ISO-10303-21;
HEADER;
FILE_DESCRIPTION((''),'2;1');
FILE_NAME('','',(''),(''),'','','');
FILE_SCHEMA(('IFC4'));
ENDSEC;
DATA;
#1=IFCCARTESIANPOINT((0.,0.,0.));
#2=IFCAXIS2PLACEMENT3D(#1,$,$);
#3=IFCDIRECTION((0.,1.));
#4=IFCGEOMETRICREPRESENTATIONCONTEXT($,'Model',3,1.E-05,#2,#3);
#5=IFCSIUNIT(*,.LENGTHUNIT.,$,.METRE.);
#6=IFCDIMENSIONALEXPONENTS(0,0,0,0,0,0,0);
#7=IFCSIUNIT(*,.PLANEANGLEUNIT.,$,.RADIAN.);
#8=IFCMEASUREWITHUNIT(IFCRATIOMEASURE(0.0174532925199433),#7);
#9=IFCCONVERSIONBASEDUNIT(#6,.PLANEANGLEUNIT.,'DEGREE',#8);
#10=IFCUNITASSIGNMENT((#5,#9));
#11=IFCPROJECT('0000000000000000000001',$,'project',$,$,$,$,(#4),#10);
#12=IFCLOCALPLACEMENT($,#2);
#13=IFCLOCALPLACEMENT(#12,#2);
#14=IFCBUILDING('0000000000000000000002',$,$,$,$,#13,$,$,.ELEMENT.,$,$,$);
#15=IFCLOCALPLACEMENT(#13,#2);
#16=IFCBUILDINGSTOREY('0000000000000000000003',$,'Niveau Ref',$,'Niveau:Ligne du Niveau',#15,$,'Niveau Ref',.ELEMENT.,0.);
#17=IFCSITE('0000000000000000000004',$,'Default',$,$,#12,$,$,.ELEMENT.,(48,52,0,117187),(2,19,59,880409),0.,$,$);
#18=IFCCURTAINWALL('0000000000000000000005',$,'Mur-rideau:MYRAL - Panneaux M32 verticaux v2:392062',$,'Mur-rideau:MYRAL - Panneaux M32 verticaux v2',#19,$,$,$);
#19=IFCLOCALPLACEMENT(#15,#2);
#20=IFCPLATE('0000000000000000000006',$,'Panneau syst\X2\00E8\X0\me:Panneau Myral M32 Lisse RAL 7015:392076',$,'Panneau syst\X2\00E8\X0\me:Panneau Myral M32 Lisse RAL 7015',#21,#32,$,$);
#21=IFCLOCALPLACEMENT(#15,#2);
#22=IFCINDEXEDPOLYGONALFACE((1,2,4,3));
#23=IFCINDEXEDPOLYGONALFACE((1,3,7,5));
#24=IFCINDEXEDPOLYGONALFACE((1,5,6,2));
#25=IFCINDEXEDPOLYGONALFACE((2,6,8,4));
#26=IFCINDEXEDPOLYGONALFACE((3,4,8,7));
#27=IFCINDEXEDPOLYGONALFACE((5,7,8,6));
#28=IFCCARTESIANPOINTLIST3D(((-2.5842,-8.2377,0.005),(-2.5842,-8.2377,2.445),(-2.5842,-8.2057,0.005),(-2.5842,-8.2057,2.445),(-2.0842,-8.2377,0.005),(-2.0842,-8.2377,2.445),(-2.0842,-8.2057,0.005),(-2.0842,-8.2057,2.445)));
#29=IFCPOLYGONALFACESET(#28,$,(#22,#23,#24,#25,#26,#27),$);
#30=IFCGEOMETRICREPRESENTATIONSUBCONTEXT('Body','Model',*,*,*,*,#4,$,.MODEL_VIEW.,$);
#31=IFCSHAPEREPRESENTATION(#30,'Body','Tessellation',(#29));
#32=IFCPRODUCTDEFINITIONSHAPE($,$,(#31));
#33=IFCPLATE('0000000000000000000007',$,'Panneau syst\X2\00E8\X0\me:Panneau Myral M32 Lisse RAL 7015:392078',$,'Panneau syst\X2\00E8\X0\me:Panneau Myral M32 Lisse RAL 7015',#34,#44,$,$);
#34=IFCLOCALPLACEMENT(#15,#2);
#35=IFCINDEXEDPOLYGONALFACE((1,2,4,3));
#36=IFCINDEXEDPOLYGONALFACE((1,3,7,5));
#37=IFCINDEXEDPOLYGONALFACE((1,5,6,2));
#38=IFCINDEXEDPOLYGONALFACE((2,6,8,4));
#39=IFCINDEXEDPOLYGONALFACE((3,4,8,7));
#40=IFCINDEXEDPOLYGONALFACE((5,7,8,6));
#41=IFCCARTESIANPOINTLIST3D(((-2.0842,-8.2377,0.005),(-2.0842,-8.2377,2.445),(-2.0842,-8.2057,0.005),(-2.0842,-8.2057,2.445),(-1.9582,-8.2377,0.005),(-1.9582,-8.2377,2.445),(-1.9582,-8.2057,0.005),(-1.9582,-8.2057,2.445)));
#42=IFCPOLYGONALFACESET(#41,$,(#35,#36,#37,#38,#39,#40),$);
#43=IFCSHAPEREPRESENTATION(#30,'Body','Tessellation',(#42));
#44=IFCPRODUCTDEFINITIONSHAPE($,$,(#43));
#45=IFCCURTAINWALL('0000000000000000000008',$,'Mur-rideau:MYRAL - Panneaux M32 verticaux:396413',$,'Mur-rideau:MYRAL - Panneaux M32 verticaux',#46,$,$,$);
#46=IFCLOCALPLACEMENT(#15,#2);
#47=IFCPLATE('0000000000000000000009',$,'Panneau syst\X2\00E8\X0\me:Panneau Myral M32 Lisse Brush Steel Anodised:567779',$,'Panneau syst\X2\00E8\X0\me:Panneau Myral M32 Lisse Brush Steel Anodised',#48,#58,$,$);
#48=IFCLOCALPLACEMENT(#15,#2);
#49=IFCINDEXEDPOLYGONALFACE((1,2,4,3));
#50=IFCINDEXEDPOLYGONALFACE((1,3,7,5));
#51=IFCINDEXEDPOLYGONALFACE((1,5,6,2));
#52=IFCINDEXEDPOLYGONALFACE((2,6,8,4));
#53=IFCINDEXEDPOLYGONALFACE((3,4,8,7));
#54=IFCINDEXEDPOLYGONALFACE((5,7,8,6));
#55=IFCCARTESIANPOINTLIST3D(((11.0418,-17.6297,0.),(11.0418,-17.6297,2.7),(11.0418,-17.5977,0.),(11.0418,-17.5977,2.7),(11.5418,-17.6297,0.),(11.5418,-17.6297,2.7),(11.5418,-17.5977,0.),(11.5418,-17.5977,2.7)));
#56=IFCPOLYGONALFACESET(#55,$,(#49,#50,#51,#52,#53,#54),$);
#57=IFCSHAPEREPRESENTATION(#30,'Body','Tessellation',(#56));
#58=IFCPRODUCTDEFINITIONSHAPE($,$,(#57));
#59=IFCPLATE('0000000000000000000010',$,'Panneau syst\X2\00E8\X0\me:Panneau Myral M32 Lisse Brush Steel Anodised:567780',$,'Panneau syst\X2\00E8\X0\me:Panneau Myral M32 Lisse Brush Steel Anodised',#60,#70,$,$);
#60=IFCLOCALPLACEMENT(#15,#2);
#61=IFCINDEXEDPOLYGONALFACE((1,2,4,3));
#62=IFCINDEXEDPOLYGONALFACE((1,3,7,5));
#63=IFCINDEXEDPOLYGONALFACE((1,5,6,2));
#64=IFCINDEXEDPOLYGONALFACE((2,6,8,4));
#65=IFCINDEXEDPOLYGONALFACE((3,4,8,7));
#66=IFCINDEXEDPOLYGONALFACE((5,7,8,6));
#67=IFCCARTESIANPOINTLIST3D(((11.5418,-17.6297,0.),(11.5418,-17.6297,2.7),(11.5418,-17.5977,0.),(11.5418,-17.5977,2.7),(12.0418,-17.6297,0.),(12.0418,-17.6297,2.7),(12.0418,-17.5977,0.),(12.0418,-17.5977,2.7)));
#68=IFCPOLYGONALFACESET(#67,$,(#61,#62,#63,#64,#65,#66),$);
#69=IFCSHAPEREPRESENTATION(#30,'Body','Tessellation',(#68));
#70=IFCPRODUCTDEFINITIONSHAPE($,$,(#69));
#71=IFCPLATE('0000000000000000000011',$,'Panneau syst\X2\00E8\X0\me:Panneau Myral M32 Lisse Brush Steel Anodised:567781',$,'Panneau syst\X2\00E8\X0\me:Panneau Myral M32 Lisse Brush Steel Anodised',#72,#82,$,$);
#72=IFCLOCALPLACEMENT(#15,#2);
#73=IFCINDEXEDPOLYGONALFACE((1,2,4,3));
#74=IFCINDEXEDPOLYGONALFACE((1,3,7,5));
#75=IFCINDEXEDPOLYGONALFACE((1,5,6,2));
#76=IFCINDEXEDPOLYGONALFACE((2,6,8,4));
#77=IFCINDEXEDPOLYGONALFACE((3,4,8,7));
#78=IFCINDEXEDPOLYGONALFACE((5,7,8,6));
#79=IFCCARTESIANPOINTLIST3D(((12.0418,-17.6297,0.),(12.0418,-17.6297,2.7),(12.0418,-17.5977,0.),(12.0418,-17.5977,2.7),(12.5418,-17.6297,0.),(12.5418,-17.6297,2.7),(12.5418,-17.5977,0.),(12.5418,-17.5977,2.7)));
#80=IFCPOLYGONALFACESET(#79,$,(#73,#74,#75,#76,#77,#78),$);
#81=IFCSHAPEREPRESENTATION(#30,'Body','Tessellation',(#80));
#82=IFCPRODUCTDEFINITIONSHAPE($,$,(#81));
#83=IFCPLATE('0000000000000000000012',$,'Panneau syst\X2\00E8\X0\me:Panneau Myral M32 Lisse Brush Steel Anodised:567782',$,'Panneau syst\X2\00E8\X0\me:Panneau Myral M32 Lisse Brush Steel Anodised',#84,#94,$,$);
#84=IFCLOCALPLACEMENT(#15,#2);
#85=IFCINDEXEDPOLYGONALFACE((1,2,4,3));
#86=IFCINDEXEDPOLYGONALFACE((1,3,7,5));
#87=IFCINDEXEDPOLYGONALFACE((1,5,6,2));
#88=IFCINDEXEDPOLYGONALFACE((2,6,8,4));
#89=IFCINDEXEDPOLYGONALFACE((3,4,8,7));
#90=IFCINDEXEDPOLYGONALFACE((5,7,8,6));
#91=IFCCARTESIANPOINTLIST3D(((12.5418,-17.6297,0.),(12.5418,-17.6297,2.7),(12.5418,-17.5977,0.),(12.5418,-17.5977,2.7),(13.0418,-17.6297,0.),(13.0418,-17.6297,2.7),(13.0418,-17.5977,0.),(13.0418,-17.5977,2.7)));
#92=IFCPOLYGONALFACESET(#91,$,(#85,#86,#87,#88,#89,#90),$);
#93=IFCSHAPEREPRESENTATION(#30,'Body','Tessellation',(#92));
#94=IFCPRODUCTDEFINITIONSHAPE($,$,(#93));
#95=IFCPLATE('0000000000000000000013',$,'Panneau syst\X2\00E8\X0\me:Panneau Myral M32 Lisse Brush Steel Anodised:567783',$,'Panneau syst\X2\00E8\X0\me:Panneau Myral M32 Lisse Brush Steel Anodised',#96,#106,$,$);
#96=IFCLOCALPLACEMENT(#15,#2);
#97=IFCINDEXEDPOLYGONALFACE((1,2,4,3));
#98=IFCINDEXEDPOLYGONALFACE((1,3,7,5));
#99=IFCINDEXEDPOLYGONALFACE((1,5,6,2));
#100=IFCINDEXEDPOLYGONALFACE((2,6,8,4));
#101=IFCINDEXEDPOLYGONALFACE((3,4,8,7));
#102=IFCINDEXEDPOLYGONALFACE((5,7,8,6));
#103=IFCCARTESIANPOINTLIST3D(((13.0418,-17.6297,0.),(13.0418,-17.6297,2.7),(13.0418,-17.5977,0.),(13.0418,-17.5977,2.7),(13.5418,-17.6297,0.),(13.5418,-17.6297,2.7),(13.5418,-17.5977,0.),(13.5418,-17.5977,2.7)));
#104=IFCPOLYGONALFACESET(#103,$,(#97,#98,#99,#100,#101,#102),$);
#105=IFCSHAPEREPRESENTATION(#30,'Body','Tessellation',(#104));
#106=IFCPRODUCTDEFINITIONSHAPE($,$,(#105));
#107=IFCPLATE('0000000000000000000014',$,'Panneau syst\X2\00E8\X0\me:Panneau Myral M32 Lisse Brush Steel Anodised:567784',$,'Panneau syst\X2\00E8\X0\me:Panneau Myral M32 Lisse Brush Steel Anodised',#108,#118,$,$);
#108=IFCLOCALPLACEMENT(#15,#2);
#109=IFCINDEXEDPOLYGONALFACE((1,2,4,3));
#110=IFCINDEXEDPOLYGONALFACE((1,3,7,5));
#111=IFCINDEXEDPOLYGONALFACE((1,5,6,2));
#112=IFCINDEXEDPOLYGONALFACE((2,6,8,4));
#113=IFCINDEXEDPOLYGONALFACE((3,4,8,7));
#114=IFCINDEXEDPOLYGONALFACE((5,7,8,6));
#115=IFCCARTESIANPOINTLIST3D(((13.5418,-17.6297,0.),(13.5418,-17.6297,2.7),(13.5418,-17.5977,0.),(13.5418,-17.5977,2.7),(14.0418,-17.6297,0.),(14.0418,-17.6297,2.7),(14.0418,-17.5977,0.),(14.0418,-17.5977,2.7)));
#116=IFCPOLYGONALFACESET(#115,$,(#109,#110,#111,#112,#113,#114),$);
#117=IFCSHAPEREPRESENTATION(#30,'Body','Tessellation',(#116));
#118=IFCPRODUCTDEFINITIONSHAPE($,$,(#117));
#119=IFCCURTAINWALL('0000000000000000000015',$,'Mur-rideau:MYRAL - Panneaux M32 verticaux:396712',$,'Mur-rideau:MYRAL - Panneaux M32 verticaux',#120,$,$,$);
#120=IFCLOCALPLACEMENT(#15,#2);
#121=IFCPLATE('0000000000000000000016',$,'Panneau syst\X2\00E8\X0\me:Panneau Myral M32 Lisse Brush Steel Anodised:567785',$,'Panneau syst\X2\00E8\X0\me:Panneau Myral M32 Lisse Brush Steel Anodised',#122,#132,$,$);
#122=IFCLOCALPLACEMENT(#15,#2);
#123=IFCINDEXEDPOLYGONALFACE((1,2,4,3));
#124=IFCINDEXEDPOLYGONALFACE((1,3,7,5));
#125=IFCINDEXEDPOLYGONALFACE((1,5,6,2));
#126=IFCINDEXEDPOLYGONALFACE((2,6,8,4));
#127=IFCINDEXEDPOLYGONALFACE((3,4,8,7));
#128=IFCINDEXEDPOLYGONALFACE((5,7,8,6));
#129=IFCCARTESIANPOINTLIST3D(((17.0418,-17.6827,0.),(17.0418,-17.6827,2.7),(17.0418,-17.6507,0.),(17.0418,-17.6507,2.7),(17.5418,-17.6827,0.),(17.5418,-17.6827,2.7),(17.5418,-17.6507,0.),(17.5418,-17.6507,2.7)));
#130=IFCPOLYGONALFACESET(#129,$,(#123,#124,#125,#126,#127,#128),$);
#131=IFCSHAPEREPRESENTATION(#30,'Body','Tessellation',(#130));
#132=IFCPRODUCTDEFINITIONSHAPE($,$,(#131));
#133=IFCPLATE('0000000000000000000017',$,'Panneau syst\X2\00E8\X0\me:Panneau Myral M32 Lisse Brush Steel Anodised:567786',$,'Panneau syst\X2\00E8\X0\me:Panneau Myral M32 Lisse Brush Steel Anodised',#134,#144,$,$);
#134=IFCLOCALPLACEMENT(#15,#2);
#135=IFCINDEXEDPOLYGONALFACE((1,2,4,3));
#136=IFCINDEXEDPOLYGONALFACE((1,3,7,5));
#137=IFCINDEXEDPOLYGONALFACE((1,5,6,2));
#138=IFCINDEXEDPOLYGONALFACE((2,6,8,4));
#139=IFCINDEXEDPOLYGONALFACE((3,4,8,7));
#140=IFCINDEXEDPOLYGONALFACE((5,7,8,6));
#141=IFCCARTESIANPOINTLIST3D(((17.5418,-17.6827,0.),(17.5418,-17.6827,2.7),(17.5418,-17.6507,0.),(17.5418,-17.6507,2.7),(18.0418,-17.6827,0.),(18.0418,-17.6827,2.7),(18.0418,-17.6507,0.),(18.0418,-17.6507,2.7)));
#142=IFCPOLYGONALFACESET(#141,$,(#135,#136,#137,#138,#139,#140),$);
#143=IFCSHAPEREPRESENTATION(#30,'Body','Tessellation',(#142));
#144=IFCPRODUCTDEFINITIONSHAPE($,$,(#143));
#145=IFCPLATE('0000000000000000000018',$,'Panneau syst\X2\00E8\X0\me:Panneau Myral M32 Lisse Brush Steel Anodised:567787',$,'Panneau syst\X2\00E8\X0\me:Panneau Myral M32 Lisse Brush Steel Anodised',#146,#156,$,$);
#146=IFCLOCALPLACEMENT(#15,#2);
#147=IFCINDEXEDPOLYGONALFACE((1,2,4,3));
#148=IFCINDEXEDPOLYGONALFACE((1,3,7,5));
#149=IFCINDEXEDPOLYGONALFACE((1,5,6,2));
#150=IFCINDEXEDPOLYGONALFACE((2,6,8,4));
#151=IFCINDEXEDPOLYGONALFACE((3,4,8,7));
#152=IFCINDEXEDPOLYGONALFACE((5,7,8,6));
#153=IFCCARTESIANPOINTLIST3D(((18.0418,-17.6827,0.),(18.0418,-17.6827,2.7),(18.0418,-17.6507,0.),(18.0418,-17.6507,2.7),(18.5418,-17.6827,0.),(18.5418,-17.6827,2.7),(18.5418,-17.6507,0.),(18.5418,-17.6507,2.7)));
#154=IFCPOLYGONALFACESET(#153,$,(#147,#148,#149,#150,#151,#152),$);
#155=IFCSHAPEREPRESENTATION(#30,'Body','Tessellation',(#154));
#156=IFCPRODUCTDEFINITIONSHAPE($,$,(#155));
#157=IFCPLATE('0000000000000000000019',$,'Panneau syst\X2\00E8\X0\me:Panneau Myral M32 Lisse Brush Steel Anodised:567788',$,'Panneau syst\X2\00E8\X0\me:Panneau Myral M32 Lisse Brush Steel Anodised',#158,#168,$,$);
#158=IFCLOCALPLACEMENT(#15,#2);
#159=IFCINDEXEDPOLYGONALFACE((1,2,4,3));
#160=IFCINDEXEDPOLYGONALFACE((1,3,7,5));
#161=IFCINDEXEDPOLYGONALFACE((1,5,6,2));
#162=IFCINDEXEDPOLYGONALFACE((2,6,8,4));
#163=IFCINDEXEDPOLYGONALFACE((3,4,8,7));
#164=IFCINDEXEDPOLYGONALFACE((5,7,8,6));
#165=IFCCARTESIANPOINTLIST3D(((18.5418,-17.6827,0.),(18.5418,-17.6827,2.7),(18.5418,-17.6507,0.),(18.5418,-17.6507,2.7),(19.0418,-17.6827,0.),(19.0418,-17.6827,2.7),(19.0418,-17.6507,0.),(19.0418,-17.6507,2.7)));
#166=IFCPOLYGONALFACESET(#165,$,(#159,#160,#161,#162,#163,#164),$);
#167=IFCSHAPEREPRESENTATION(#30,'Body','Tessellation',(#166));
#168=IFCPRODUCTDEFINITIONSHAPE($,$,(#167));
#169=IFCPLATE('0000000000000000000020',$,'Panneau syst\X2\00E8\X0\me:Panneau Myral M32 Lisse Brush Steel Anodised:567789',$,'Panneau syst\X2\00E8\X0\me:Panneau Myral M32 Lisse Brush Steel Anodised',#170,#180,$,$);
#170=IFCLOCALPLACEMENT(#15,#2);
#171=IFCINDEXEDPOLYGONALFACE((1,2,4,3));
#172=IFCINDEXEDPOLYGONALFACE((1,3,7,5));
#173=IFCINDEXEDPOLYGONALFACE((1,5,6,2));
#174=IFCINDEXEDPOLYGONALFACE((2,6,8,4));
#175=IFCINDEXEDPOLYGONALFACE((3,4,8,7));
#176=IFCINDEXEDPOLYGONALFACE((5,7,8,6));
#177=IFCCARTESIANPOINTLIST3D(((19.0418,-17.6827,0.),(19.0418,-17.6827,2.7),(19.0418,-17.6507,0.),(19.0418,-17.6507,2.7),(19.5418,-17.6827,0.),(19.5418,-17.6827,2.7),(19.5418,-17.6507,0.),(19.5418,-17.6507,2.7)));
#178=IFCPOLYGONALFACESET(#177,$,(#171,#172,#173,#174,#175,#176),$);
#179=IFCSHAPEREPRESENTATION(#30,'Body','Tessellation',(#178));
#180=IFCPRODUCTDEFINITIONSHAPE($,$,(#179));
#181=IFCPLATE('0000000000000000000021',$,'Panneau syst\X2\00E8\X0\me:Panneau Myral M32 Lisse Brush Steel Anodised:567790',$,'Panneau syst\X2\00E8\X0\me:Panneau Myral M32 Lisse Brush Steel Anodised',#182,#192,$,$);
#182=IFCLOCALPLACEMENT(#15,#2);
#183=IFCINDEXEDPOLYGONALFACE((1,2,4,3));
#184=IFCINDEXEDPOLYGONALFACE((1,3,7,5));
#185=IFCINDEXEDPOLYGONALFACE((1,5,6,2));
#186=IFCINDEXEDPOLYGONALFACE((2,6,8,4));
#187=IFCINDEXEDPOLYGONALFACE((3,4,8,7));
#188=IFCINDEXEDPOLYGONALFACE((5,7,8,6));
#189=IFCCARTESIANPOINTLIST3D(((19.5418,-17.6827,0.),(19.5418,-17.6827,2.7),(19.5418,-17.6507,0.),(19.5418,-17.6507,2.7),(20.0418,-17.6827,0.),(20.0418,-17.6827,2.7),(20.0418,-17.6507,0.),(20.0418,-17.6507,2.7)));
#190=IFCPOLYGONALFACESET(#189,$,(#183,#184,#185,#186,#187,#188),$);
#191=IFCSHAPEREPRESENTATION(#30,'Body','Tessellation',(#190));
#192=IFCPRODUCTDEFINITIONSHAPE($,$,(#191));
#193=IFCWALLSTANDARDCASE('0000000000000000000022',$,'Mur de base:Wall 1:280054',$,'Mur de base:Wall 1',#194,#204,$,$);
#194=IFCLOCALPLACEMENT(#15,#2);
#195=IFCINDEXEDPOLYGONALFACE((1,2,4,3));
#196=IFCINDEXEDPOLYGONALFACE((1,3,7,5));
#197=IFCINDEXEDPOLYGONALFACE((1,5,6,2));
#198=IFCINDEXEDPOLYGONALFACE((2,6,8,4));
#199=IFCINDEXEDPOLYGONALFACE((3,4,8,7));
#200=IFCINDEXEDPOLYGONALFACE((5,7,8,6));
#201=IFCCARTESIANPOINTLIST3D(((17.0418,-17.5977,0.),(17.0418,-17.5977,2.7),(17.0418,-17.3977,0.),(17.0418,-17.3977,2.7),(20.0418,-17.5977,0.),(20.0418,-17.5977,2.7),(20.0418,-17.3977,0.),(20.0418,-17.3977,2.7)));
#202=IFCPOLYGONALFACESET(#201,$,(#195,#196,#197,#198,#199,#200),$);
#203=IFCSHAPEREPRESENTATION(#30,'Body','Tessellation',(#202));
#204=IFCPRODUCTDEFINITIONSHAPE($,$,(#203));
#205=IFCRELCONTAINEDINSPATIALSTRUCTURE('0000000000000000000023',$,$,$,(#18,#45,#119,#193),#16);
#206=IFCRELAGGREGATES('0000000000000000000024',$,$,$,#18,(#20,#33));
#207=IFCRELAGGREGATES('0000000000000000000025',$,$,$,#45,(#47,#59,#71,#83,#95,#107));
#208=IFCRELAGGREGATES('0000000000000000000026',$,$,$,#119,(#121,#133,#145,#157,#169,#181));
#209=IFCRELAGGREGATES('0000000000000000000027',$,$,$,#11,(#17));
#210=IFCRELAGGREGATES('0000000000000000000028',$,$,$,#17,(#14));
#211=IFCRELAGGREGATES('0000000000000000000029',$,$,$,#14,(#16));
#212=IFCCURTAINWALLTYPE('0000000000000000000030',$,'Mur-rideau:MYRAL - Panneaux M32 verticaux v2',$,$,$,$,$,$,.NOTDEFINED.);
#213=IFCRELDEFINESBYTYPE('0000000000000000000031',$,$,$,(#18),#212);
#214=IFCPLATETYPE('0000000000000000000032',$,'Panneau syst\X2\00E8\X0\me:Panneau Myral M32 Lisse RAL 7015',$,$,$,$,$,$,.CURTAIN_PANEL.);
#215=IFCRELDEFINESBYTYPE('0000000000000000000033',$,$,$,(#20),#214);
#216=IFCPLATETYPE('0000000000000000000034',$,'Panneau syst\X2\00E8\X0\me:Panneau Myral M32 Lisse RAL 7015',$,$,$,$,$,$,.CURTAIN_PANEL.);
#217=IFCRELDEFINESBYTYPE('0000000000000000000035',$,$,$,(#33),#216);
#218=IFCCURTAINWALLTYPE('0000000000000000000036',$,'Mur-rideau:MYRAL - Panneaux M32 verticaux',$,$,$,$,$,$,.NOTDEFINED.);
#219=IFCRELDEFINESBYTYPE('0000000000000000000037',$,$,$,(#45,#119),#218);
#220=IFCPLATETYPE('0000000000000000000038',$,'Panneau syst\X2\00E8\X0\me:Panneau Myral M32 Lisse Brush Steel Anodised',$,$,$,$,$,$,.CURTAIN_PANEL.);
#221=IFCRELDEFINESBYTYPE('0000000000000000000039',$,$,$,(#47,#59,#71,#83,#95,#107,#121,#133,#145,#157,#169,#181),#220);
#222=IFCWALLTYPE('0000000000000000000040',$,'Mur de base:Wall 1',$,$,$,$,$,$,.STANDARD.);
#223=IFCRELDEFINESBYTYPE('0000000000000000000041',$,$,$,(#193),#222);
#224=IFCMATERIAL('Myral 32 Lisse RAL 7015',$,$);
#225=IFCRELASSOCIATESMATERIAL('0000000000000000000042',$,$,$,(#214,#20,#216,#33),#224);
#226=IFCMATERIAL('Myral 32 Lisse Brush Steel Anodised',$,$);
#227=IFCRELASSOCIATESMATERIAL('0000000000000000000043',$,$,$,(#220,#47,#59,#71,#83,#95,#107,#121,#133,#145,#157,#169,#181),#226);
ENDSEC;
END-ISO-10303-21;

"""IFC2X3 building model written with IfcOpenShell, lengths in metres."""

from ifc_helpers import new_model, entity, si_unit, converted_unit, direction, frame, frame_2d, origin, origin_2d_with_axis, place, context, subcontext, project, spatial, rectangle, extrude, source, transform, mapped, material, type_object, type_shapes, element, aggregate, save


model = new_model("IFC2X3")

# Units and contexts
model_context = context("Model", 3, precision=1e-05, world=origin(), true_north=direction((0.0, 1.0)))
body_context = subcontext(model_context, "Body", "Model", "MODEL_VIEW")
ifc_project = project(units=[si_unit("LENGTHUNIT", "METRE"), converted_unit("PLANEANGLEUNIT", "DEGREE", entity("IfcRatioMeasure", 0.0174532925199433), si_unit("PLANEANGLEUNIT", "RADIAN"), dimensions=[0, 0, 0, 0, 0, 0, 0])], contexts=[model_context])

# Site, building, storey
site_placement = place(None, origin())
site = spatial("IfcSite", under=ifc_project, at=site_placement, Name="Default", CompositionType="ELEMENT", RefLatitude=(48, 52, 0, 117187), RefLongitude=(2, 19, 59, 880409), RefElevation=0.0)
building_placement = place(site_placement, origin())
building = spatial("IfcBuilding", under=site, at=building_placement, CompositionType="ELEMENT")
storey_placement = place(building_placement, origin())
storey = spatial("IfcBuildingStorey", under=building, at=storey_placement, Name="Niveau Ref", ObjectType="Niveau:Ligne du Niveau", LongName="Niveau Ref", CompositionType="ELEMENT", Elevation=0.0)

# Curtain walls, plates
curtain_wall_type_1 = type_object("IfcCurtainWallType", Name="Mur-rideau:MYRAL - Panneaux M32 verticaux v2", PredefinedType="NOTDEFINED")
curtain_wall_1_placement = place(storey_placement, origin())
curtain_wall_1 = element("IfcCurtainWall", 1, at=curtain_wall_1_placement, inside=storey, type_object=curtain_wall_type_1, Name="Mur-rideau:MYRAL - Panneaux M32 verticaux v2:392062", ObjectType="Mur-rideau:MYRAL - Panneaux M32 verticaux v2")
ifc_material_1 = material(Name="Myral 32 Lisse RAL 7015")
plate_type_1 = type_object("IfcPlateType", Name="Panneau système:Panneau Myral M32 Lisse RAL 7015", PredefinedType="CURTAIN_PANEL", material=ifc_material_1)
shared_shape_1 = source(origin(), body_context, "Body", "SweptSolid", [
    extrude(rectangle(XDim=0.032, YDim=0.5, at=origin_2d_with_axis()), frame((0.0, -0.016, 0.0), z_axis=(0.0, 0.0, 1.0), x_axis=(0.0, 1.0, 0.0)), (0.0, 0.0, 1.0), 2.44),
])
type_shapes(plate_type_1, [shared_shape_1])
plate_1_placement = place(curtain_wall_1_placement, frame((-2.3342, -8.2057, 0.005)))
plate_1 = element("IfcPlate", 2, at=plate_1_placement, type_object=plate_type_1, material=ifc_material_1, Name="Panneau système:Panneau Myral M32 Lisse RAL 7015:392076", ObjectType="Panneau système:Panneau Myral M32 Lisse RAL 7015", context=body_context, shape_type="MappedRepresentation", body=[
    mapped(shared_shape_1, transform((0.0, 0.0, 0.0), scale=1.0)),
])
plate_type_2 = type_object("IfcPlateType", Name="Panneau système:Panneau Myral M32 Lisse RAL 7015", PredefinedType="CURTAIN_PANEL", material=ifc_material_1)
shared_shape_2 = source(origin(), body_context, "Body", "SweptSolid", [
    extrude(rectangle(XDim=0.032, YDim=0.126, at=origin_2d_with_axis()), frame((0.0, -0.016, 0.0), z_axis=(0.0, 0.0, 1.0), x_axis=(0.0, 1.0, 0.0)), (0.0, 0.0, 1.0), 2.44),
])
type_shapes(plate_type_2, [shared_shape_2])
plate_2_placement = place(curtain_wall_1_placement, frame((-2.0212, -8.2057, 0.005)))
plate_2 = element("IfcPlate", 3, at=plate_2_placement, type_object=plate_type_2, material=ifc_material_1, Name="Panneau système:Panneau Myral M32 Lisse RAL 7015:392078", ObjectType="Panneau système:Panneau Myral M32 Lisse RAL 7015", context=body_context, shape_type="MappedRepresentation", body=[
    mapped(shared_shape_2, transform((0.0, 0.0, 0.0), scale=1.0)),
])
aggregate(curtain_wall_1, [plate_1, plate_2])
curtain_wall_type_2 = type_object("IfcCurtainWallType", Name="Mur-rideau:MYRAL - Panneaux M32 verticaux", PredefinedType="NOTDEFINED")
curtain_wall_2_placement = place(storey_placement, origin())
curtain_wall_2 = element("IfcCurtainWall", 4, at=curtain_wall_2_placement, inside=storey, type_object=curtain_wall_type_2, Name="Mur-rideau:MYRAL - Panneaux M32 verticaux:396413", ObjectType="Mur-rideau:MYRAL - Panneaux M32 verticaux")
ifc_material_2 = material(Name="Myral 32 Lisse Brush Steel Anodised")
plate_type_3 = type_object("IfcPlateType", Name="Panneau système:Panneau Myral M32 Lisse Brush Steel Anodised", PredefinedType="CURTAIN_PANEL", material=ifc_material_2)
shared_shape_3 = source(origin(), body_context, "Body", "SweptSolid", [
    extrude(rectangle(XDim=0.032, YDim=0.5, at=origin_2d_with_axis()), frame((0.0, -0.016, 0.0), z_axis=(0.0, 0.0, 1.0), x_axis=(0.0, 1.0, 0.0)), (0.0, 0.0, 1.0), 2.7),
])
type_shapes(plate_type_3, [shared_shape_3])
plate_3_placement = place(curtain_wall_2_placement, frame((11.2918, -17.5977, 0.0)))
plate_3 = element("IfcPlate", 5, at=plate_3_placement, type_object=plate_type_3, material=ifc_material_2, Name="Panneau système:Panneau Myral M32 Lisse Brush Steel Anodised:567779", ObjectType="Panneau système:Panneau Myral M32 Lisse Brush Steel Anodised", context=body_context, shape_type="MappedRepresentation", body=[
    mapped(shared_shape_3, transform((0.0, 0.0, 0.0), scale=1.0)),
])
plate_4_placement = place(curtain_wall_2_placement, frame((11.7918, -17.5977, 0.0)))
plate_4 = element("IfcPlate", 6, at=plate_4_placement, type_object=plate_type_3, material=ifc_material_2, Name="Panneau système:Panneau Myral M32 Lisse Brush Steel Anodised:567780", ObjectType="Panneau système:Panneau Myral M32 Lisse Brush Steel Anodised", context=body_context, shape_type="MappedRepresentation", body=[
    mapped(shared_shape_3, transform((0.0, 0.0, 0.0), scale=1.0)),
])
plate_5_placement = place(curtain_wall_2_placement, frame((12.2918, -17.5977, 0.0)))
plate_5 = element("IfcPlate", 7, at=plate_5_placement, type_object=plate_type_3, material=ifc_material_2, Name="Panneau système:Panneau Myral M32 Lisse Brush Steel Anodised:567781", ObjectType="Panneau système:Panneau Myral M32 Lisse Brush Steel Anodised", context=body_context, shape_type="MappedRepresentation", body=[
    mapped(shared_shape_3, transform((0.0, 0.0, 0.0), scale=1.0)),
])
plate_6_placement = place(curtain_wall_2_placement, frame((12.7918, -17.5977, 0.0)))
plate_6 = element("IfcPlate", 8, at=plate_6_placement, type_object=plate_type_3, material=ifc_material_2, Name="Panneau système:Panneau Myral M32 Lisse Brush Steel Anodised:567782", ObjectType="Panneau système:Panneau Myral M32 Lisse Brush Steel Anodised", context=body_context, shape_type="MappedRepresentation", body=[
    mapped(shared_shape_3, transform((0.0, 0.0, 0.0), scale=1.0)),
])
plate_7_placement = place(curtain_wall_2_placement, frame((13.2918, -17.5977, 0.0)))
plate_7 = element("IfcPlate", 9, at=plate_7_placement, type_object=plate_type_3, material=ifc_material_2, Name="Panneau système:Panneau Myral M32 Lisse Brush Steel Anodised:567783", ObjectType="Panneau système:Panneau Myral M32 Lisse Brush Steel Anodised", context=body_context, shape_type="MappedRepresentation", body=[
    mapped(shared_shape_3, transform((0.0, 0.0, 0.0), scale=1.0)),
])
plate_8_placement = place(curtain_wall_2_placement, frame((13.7918, -17.5977, 0.0)))
plate_8 = element("IfcPlate", 10, at=plate_8_placement, type_object=plate_type_3, material=ifc_material_2, Name="Panneau système:Panneau Myral M32 Lisse Brush Steel Anodised:567784", ObjectType="Panneau système:Panneau Myral M32 Lisse Brush Steel Anodised", context=body_context, shape_type="MappedRepresentation", body=[
    mapped(shared_shape_3, transform((0.0, 0.0, 0.0), scale=1.0)),
])
aggregate(curtain_wall_2, [plate_3, plate_4, plate_5, plate_6, plate_7, plate_8])
curtain_wall_3_placement = place(storey_placement, origin())
curtain_wall_3 = element("IfcCurtainWall", 11, at=curtain_wall_3_placement, inside=storey, type_object=curtain_wall_type_2, Name="Mur-rideau:MYRAL - Panneaux M32 verticaux:396712", ObjectType="Mur-rideau:MYRAL - Panneaux M32 verticaux")
plate_9_placement = place(curtain_wall_3_placement, frame((17.2918, -17.6507, 0.0)))
plate_9 = element("IfcPlate", 12, at=plate_9_placement, type_object=plate_type_3, material=ifc_material_2, Name="Panneau système:Panneau Myral M32 Lisse Brush Steel Anodised:567785", ObjectType="Panneau système:Panneau Myral M32 Lisse Brush Steel Anodised", context=body_context, shape_type="MappedRepresentation", body=[
    mapped(shared_shape_3, transform((0.0, 0.0, 0.0), scale=1.0)),
])
plate_10_placement = place(curtain_wall_3_placement, frame((17.7918, -17.6507, 0.0)))
plate_10 = element("IfcPlate", 13, at=plate_10_placement, type_object=plate_type_3, material=ifc_material_2, Name="Panneau système:Panneau Myral M32 Lisse Brush Steel Anodised:567786", ObjectType="Panneau système:Panneau Myral M32 Lisse Brush Steel Anodised", context=body_context, shape_type="MappedRepresentation", body=[
    mapped(shared_shape_3, transform((0.0, 0.0, 0.0), scale=1.0)),
])
plate_11_placement = place(curtain_wall_3_placement, frame((18.2918, -17.6507, 0.0)))
plate_11 = element("IfcPlate", 14, at=plate_11_placement, type_object=plate_type_3, material=ifc_material_2, Name="Panneau système:Panneau Myral M32 Lisse Brush Steel Anodised:567787", ObjectType="Panneau système:Panneau Myral M32 Lisse Brush Steel Anodised", context=body_context, shape_type="MappedRepresentation", body=[
    mapped(shared_shape_3, transform((0.0, 0.0, 0.0), scale=1.0)),
])
plate_12_placement = place(curtain_wall_3_placement, frame((18.7918, -17.6507, 0.0)))
plate_12 = element("IfcPlate", 15, at=plate_12_placement, type_object=plate_type_3, material=ifc_material_2, Name="Panneau système:Panneau Myral M32 Lisse Brush Steel Anodised:567788", ObjectType="Panneau système:Panneau Myral M32 Lisse Brush Steel Anodised", context=body_context, shape_type="MappedRepresentation", body=[
    mapped(shared_shape_3, transform((0.0, 0.0, 0.0), scale=1.0)),
])
plate_13_placement = place(curtain_wall_3_placement, frame((19.2918, -17.6507, 0.0)))
plate_13 = element("IfcPlate", 16, at=plate_13_placement, type_object=plate_type_3, material=ifc_material_2, Name="Panneau système:Panneau Myral M32 Lisse Brush Steel Anodised:567789", ObjectType="Panneau système:Panneau Myral M32 Lisse Brush Steel Anodised", context=body_context, shape_type="MappedRepresentation", body=[
    mapped(shared_shape_3, transform((0.0, 0.0, 0.0), scale=1.0)),
])
plate_14_placement = place(curtain_wall_3_placement, frame((19.7918, -17.6507, 0.0)))
plate_14 = element("IfcPlate", 17, at=plate_14_placement, type_object=plate_type_3, material=ifc_material_2, Name="Panneau système:Panneau Myral M32 Lisse Brush Steel Anodised:567790", ObjectType="Panneau système:Panneau Myral M32 Lisse Brush Steel Anodised", context=body_context, shape_type="MappedRepresentation", body=[
    mapped(shared_shape_3, transform((0.0, 0.0, 0.0), scale=1.0)),
])
aggregate(curtain_wall_3, [plate_9, plate_10, plate_11, plate_12, plate_13, plate_14])

# Wall
wall_type_1 = type_object("IfcWallType", Name="Mur de base:Wall 1", PredefinedType="STANDARD")
for number, where, name in (
    (18, (17.0418, -17.4977, 0.0), "Mur de base:Wall 1:280054"),
):
    element("IfcWallStandardCase", number, at=place(storey_placement, frame(where)), inside=storey, type_object=wall_type_1, Name=name, ObjectType="Mur de base:Wall 1", context=body_context, shape_type="SweptSolid", body=[
        extrude(rectangle(XDim=3.0, YDim=0.2, at=frame_2d((1.5, 0.0), x_axis=(-1.0, 0.0))), origin(), (0.0, 0.0, 1.0), 2.7),
    ])

save(model, "model.ifc")
